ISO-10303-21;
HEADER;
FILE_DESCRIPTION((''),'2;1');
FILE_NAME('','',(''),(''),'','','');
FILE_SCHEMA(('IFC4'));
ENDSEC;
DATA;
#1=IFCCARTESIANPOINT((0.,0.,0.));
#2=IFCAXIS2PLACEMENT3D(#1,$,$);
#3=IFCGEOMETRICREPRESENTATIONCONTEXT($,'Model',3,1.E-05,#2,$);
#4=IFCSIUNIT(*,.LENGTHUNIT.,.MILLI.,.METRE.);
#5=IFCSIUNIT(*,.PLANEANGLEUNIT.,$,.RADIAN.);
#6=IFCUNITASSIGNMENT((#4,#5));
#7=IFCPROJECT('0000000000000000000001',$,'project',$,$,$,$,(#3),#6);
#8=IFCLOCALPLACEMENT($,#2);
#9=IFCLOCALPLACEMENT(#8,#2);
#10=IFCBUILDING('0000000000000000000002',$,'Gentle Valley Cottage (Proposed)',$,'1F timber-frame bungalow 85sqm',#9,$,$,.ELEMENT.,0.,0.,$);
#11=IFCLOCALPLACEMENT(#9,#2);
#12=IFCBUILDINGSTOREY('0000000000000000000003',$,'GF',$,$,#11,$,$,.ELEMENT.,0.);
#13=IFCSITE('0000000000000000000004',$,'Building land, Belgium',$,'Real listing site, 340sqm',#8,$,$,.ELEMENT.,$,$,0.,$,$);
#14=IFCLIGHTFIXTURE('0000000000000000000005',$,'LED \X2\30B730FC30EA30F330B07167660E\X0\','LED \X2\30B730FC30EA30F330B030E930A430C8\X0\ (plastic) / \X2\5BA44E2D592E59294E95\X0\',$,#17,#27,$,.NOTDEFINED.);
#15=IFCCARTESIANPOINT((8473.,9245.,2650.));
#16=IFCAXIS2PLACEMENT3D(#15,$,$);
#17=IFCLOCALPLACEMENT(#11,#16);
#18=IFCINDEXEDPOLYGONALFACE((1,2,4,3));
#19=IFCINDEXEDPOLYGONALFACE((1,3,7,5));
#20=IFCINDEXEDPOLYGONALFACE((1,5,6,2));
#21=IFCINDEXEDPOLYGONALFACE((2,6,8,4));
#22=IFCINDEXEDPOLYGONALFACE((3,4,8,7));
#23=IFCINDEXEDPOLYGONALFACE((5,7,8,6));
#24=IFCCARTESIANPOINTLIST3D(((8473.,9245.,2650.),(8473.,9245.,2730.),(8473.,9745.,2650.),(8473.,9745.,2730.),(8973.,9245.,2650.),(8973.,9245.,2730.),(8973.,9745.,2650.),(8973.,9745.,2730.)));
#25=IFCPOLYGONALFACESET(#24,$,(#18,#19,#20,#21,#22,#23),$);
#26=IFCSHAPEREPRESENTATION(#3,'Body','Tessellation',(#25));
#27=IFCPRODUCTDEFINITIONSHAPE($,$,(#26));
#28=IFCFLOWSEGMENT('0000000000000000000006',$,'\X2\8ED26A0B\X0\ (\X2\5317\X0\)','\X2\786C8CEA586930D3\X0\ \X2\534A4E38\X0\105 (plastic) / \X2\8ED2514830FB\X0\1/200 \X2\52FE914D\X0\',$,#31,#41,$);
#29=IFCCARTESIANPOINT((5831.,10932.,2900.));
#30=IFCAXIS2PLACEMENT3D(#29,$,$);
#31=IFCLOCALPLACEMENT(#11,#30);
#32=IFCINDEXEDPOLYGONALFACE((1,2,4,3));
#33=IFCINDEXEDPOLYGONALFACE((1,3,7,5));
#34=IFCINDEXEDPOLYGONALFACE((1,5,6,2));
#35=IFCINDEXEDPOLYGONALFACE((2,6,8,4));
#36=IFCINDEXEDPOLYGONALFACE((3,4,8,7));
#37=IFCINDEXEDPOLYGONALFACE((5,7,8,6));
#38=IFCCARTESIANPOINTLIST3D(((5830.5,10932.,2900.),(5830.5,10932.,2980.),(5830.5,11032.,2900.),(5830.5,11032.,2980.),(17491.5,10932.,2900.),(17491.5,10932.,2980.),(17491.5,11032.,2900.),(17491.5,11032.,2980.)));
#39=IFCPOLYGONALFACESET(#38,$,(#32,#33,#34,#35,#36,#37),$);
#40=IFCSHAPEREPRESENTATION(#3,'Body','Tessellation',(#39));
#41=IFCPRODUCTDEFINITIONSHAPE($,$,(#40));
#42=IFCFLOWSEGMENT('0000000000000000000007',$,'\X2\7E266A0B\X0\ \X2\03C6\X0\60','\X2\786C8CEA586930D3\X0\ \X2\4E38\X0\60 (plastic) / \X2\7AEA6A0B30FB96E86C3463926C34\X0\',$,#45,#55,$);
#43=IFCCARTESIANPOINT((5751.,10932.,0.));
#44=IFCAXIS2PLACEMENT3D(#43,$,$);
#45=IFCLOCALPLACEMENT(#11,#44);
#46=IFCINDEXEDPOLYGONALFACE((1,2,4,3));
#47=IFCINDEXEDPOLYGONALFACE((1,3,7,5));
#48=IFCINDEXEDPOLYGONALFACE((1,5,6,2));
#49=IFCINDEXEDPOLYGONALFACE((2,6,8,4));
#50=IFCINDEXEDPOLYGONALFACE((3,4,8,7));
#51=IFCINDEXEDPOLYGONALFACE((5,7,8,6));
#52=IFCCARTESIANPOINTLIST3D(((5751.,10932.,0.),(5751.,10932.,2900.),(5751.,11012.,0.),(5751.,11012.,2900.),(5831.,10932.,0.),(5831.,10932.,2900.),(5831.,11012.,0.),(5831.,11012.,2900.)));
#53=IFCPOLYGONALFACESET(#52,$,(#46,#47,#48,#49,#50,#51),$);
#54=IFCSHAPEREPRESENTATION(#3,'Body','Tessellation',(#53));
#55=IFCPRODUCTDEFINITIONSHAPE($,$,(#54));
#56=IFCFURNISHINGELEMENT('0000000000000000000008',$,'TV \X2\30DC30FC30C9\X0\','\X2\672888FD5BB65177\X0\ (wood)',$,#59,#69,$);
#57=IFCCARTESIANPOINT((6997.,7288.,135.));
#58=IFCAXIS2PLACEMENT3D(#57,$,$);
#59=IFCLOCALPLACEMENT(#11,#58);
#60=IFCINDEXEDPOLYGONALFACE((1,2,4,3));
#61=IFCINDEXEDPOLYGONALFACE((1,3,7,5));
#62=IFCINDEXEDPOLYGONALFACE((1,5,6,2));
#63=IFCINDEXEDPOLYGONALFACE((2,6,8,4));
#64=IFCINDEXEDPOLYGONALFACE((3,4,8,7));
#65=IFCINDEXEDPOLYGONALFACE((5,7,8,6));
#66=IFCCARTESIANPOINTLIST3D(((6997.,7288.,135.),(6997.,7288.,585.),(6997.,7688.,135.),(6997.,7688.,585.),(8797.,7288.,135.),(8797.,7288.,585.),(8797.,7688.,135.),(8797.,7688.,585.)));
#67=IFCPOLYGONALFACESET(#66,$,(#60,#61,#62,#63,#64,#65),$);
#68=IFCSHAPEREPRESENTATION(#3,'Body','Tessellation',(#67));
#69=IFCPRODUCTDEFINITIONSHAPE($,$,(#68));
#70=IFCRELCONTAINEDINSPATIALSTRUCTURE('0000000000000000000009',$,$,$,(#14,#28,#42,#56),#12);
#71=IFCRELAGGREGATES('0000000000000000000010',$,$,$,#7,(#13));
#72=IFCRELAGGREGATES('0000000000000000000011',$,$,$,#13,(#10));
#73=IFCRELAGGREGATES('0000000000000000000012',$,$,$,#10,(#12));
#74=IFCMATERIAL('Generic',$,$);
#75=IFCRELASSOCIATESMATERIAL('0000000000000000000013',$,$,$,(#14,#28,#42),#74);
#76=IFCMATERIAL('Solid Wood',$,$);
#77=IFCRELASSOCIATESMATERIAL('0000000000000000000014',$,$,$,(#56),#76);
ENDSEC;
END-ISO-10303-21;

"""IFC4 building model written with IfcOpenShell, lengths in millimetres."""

from ifc_helpers import new_model, si_unit, frame, frame_2d, origin, place, context, project, spatial, rectangle, extrude, material, element, save


model = new_model("IFC4")

# Units and contexts
model_context = context("Model", 3, precision=1e-05, world=origin())
ifc_project = project(units=[si_unit("LENGTHUNIT", "METRE", prefix="MILLI"), si_unit("PLANEANGLEUNIT", "RADIAN")], contexts=[model_context])

# Site, building, storey
site_placement = place(None, origin())
site = spatial("IfcSite", under=ifc_project, at=site_placement, Name="Building land, Belgium", ObjectType="Real listing site, 340sqm", CompositionType="ELEMENT", RefElevation=0.0)
building_placement = place(site_placement, origin())
building = spatial("IfcBuilding", under=site, at=building_placement, Name="Gentle Valley Cottage (Proposed)", ObjectType="1F timber-frame bungalow 85sqm", CompositionType="ELEMENT", ElevationOfRefHeight=0.0, ElevationOfTerrain=0.0)
storey_placement = place(building_placement, origin())
storey = spatial("IfcBuildingStorey", under=building, at=storey_placement, Name="GF", CompositionType="ELEMENT", Elevation=0.0)

# Shared definitions
ifc_material_1 = material(Name="Solid Wood")

# Shared definitions
ifc_material_2 = material(Name="Generic")

# Light fixture
light_fixture_placement = place(storey_placement, frame((8473.0, 9245.0, 2650.0)))
element("IfcLightFixture", 1, at=light_fixture_placement, inside=storey, material=ifc_material_2, Name="LED シーリング照明", Description="LED シーリングライト (plastic) / 室中央天井", PredefinedType="NOTDEFINED", context=model_context, shape_type="SweptSolid", body=[
    extrude(rectangle(XDim=500.0, YDim=500.0, at=frame_2d((250.0, 250.0))), frame((8473.0, 9245.0, 2650.0)), (0.0, 0.0, 1.0), 80.0),
])

# Flow segments
flow_segment_1_placement = place(storey_placement, frame((5831.0, 10932.0, 2900.0)))
element("IfcFlowSegment", 2, at=flow_segment_1_placement, inside=storey, material=ifc_material_2, Name="軒樋 (北)", Description="硬質塩ビ 半丸105 (plastic) / 軒先・1/200 勾配", context=model_context, shape_type="SweptSolid", body=[
    extrude(rectangle(XDim=11661.0, YDim=100.0, at=frame_2d((5830.0, 50.0))), frame((5831.0, 10932.0, 2900.0)), (0.0, 0.0, 1.0), 80.0),
])
flow_segment_2_placement = place(storey_placement, frame((5751.0, 10932.0, 0.0)))
element("IfcFlowSegment", 3, at=flow_segment_2_placement, inside=storey, material=ifc_material_2, Name="縦樋 φ60", Description="硬質塩ビ 丸60 (plastic) / 竪樋・雨水排水", context=model_context, shape_type="SweptSolid", body=[
    extrude(rectangle(XDim=80.0, YDim=80.0, at=frame_2d((40.0, 40.0))), frame((5751.0, 10932.0, 0.0)), (0.0, 0.0, 1.0), 2900.0),
])

# Furnishing element
furnishing_placement = place(storey_placement, frame((6997.0, 7288.0, 135.0)))
element("IfcFurnishingElement", 4, at=furnishing_placement, inside=storey, material=ifc_material_1, Name="TV ボード", Description="木製家具 (wood)", context=model_context, shape_type="SweptSolid", body=[
    extrude(rectangle(XDim=1800.0, YDim=400.0, at=frame_2d((900.0, 200.0))), frame((6997.0, 7288.0, 135.0)), (0.0, 0.0, 1.0), 450.0),
])

save(model, "model.ifc")
